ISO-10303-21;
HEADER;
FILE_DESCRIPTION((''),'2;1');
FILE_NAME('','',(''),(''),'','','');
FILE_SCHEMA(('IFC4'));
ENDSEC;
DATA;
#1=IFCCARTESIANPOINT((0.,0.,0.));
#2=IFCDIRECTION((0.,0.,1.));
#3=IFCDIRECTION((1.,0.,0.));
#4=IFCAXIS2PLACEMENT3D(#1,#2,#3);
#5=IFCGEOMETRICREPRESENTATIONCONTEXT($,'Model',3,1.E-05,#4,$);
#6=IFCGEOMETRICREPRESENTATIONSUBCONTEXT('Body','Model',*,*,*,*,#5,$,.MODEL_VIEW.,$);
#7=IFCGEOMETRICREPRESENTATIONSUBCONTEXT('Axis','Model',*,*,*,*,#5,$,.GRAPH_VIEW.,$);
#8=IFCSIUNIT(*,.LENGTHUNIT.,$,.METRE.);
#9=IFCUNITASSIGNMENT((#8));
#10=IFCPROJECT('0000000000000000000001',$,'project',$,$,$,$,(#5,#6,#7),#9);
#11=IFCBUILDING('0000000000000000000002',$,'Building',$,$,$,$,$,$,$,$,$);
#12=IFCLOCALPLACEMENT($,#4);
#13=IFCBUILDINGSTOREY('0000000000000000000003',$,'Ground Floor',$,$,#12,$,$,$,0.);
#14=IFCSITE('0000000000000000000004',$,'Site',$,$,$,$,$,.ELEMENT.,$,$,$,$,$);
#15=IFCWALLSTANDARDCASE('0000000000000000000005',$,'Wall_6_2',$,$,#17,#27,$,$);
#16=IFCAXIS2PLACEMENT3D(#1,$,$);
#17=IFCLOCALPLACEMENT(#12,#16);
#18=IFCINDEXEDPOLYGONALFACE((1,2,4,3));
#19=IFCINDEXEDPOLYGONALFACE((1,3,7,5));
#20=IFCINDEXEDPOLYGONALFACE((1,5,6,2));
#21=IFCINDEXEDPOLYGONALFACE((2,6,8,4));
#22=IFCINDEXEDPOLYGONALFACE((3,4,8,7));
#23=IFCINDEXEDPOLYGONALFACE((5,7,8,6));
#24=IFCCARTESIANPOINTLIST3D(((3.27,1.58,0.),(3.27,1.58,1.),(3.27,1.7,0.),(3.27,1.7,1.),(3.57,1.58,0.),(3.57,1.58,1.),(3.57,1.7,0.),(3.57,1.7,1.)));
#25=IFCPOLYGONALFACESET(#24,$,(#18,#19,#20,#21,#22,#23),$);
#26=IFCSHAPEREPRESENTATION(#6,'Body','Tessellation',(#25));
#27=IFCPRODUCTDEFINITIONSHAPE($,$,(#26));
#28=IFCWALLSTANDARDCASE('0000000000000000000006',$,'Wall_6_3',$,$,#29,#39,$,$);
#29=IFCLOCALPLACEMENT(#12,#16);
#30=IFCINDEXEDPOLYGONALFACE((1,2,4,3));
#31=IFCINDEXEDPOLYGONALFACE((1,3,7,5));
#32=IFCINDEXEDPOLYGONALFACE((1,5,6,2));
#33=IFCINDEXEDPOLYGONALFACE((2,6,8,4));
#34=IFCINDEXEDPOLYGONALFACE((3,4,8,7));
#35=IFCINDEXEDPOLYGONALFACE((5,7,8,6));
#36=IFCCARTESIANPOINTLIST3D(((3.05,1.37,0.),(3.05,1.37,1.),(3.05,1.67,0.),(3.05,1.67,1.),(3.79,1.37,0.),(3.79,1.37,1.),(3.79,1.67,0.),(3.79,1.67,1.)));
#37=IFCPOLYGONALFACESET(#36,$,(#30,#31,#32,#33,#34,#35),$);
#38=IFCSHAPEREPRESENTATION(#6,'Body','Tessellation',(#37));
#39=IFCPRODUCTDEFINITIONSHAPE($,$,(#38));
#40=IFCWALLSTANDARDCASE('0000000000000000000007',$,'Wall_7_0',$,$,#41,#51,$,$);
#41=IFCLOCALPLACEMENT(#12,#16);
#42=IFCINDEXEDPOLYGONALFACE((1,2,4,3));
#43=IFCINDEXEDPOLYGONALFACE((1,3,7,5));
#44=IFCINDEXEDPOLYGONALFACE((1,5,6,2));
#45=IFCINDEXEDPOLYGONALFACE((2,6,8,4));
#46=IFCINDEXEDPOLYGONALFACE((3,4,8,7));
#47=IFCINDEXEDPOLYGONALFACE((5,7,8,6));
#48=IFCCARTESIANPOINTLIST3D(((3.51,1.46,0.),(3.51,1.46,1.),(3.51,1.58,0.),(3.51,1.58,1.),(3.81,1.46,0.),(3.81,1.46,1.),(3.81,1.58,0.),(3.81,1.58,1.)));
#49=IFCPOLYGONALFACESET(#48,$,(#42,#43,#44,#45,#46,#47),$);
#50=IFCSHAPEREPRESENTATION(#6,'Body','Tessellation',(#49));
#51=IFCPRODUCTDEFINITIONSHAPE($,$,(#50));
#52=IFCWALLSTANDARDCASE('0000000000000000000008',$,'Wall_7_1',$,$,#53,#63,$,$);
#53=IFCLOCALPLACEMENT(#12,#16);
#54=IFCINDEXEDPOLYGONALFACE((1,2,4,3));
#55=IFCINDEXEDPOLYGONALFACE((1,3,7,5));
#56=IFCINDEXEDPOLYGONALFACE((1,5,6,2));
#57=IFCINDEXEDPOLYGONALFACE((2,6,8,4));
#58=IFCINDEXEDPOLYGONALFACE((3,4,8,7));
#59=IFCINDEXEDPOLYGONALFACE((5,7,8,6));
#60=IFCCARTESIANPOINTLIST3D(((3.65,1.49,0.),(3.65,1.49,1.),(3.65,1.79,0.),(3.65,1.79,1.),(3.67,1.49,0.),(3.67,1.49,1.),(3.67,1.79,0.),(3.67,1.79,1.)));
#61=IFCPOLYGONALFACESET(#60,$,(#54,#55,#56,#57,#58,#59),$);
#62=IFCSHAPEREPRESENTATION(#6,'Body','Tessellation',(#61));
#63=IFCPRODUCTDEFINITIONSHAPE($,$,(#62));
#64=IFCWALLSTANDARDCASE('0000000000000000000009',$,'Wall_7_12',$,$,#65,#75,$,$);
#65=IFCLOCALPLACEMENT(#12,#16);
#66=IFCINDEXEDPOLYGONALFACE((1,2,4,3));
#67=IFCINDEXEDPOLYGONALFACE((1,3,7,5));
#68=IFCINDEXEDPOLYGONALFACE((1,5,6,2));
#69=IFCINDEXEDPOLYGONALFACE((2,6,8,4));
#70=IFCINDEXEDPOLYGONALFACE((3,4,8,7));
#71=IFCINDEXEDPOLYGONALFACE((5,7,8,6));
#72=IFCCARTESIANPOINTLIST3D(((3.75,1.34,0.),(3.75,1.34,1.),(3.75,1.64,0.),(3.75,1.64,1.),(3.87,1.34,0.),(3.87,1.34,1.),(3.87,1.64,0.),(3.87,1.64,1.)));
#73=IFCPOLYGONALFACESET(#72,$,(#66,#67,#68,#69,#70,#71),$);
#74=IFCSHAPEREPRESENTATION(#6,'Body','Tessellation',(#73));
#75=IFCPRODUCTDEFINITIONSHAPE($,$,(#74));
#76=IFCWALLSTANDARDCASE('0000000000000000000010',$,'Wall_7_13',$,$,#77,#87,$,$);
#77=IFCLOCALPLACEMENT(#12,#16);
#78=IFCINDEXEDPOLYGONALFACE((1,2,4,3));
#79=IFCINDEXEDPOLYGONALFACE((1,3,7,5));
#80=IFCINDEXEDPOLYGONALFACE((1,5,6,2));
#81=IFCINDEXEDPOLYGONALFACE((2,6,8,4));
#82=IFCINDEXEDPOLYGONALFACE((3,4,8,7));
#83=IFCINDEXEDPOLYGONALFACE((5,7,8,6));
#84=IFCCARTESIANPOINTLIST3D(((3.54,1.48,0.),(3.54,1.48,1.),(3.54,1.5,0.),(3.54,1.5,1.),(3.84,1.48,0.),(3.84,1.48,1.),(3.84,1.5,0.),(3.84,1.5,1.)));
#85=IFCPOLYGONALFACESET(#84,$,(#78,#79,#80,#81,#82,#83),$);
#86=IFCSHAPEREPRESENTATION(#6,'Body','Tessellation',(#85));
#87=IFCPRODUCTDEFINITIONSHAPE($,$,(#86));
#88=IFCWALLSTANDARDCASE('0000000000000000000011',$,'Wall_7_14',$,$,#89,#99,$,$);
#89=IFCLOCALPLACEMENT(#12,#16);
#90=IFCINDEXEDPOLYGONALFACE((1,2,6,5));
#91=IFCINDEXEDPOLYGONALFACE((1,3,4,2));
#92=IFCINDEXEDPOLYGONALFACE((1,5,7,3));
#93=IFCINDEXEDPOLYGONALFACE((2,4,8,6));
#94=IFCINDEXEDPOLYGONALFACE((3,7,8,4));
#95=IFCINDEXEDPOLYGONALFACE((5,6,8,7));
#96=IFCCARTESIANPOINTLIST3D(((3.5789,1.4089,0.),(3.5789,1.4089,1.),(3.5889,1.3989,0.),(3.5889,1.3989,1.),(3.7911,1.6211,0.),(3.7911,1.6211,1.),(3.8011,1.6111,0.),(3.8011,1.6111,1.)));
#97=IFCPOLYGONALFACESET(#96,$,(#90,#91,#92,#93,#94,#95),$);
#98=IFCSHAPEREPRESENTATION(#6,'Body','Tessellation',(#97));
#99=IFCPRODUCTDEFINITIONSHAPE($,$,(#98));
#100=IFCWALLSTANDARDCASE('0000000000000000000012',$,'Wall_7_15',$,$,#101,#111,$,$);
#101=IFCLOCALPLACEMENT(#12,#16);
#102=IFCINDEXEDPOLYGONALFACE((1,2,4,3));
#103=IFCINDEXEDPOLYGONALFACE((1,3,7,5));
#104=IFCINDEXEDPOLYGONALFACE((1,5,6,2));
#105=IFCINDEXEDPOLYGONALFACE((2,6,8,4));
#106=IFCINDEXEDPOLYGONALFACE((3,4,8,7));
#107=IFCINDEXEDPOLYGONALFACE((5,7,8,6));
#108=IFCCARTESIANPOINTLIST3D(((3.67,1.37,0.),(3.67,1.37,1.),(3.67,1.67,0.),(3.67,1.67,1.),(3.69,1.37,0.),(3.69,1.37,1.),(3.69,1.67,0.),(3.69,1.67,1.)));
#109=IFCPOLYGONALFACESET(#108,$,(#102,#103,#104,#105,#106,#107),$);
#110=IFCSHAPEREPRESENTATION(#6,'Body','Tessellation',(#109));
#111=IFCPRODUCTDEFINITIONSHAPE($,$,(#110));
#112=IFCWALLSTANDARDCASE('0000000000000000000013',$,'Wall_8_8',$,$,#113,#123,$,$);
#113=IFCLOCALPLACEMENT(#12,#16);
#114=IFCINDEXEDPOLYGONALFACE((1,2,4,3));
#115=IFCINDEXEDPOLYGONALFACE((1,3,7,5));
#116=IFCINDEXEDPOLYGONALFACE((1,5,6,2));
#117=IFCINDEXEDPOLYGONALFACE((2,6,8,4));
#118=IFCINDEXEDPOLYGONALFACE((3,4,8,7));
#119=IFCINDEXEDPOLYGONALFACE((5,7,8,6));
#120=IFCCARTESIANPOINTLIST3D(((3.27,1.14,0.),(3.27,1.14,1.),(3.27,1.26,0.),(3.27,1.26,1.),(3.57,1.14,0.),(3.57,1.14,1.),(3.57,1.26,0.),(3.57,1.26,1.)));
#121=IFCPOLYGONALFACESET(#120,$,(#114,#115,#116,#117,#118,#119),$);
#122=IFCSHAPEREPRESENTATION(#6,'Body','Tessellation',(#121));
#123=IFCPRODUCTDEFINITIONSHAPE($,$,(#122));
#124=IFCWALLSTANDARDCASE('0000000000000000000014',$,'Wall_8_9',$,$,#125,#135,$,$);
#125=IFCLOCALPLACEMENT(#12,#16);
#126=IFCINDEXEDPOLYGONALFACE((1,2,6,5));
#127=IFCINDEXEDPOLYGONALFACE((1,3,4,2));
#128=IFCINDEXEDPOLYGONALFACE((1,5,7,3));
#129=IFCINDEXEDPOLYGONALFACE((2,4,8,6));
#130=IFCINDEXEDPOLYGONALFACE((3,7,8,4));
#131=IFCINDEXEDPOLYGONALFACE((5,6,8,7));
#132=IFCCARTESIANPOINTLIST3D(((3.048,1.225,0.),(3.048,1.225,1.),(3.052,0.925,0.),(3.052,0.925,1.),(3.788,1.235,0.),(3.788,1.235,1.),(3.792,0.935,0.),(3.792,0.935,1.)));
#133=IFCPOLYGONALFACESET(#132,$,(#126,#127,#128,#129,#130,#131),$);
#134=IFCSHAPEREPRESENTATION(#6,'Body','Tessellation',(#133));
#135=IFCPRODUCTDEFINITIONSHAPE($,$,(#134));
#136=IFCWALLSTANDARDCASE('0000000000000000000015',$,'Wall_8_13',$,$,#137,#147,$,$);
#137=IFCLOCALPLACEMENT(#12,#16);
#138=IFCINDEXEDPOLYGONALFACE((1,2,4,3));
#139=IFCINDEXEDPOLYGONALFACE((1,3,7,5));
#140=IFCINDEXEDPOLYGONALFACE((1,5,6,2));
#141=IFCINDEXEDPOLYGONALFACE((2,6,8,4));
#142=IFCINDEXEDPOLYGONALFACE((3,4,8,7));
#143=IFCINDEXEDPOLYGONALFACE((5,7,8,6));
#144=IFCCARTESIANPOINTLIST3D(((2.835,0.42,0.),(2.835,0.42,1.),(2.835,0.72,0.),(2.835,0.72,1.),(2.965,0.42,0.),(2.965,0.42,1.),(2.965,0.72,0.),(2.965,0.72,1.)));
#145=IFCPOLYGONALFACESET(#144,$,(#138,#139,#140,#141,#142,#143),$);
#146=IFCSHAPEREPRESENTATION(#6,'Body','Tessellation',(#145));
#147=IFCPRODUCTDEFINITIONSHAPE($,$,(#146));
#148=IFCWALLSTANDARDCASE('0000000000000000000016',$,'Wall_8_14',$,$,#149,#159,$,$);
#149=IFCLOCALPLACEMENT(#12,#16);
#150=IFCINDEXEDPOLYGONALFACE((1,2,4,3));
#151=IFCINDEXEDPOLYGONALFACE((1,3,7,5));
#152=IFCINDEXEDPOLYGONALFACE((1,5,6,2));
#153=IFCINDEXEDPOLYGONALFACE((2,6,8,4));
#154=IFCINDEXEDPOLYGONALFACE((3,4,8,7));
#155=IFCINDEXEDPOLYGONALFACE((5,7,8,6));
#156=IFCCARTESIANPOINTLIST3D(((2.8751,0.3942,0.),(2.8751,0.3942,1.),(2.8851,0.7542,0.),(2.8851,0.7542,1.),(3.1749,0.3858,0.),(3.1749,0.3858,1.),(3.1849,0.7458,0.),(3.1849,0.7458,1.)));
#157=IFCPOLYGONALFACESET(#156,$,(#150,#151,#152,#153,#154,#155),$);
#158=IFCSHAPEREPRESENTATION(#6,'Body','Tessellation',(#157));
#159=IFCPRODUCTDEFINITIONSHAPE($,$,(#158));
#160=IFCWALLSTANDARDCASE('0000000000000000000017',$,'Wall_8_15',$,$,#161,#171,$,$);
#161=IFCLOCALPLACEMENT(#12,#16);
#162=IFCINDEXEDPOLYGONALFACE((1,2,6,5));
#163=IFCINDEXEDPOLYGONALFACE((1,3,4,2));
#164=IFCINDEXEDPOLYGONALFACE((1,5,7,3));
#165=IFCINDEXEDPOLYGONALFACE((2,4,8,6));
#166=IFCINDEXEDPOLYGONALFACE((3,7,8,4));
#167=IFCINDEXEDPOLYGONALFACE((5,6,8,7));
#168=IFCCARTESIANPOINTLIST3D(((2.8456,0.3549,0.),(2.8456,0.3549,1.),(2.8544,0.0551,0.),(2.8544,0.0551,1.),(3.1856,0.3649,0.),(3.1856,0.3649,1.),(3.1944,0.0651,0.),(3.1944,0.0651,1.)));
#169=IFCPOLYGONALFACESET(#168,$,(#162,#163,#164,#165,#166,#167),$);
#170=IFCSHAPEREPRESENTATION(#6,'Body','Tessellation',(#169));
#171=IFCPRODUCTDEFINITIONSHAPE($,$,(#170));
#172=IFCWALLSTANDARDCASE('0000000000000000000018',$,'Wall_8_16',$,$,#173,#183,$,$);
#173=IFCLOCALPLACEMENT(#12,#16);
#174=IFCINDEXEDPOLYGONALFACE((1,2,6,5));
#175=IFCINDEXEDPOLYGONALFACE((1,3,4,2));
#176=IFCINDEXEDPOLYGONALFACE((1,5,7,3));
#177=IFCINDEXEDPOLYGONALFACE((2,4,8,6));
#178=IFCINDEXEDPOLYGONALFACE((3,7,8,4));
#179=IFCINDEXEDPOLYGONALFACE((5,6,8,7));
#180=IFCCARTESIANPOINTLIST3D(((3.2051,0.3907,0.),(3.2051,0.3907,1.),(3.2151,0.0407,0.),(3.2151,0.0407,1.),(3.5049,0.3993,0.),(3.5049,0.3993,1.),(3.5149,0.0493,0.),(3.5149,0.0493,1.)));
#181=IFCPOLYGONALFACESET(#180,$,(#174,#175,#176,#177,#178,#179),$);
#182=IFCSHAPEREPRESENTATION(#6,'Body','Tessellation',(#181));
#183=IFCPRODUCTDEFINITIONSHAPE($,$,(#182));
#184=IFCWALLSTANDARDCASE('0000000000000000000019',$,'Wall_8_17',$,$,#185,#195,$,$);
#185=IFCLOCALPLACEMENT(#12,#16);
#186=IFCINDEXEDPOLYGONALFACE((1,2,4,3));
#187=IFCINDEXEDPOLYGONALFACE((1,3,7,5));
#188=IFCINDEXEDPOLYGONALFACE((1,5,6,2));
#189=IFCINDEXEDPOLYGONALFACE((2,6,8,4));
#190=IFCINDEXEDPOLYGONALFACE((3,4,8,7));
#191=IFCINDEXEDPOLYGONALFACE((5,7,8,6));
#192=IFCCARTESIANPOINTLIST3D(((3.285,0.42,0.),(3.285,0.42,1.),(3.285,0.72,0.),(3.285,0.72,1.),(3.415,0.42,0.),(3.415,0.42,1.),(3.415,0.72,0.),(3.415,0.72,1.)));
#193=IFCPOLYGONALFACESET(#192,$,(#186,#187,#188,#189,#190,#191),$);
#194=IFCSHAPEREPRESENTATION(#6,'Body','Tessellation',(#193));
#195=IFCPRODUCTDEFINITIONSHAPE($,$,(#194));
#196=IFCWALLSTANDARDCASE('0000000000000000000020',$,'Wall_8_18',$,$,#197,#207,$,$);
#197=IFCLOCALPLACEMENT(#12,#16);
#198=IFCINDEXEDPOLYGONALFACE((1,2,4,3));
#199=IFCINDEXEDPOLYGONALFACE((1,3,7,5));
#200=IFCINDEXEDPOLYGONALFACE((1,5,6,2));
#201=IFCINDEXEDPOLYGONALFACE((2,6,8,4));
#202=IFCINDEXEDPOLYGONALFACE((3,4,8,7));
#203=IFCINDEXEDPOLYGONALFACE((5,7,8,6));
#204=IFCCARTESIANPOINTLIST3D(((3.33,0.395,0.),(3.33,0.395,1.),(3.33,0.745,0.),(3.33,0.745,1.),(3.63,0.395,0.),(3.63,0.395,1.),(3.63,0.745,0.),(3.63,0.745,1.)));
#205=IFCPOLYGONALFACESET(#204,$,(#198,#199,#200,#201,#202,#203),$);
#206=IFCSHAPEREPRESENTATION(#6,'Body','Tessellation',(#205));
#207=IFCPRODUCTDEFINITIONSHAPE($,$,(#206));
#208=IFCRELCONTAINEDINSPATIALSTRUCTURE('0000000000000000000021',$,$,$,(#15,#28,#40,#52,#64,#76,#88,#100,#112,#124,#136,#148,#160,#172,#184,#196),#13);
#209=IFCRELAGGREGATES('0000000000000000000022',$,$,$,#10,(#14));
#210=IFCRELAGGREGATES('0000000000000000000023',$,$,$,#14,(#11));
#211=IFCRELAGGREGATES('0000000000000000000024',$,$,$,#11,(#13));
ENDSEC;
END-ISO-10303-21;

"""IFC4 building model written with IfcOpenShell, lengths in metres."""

from ifc_helpers import new_model, si_unit, frame, origin_with_axes, origin_2d, place, context, subcontext, project, spatial, rectangle, extrude, element, save


model = new_model("IFC4")

# Units and contexts
model_context = context("Model", 3, precision=1e-05, world=origin_with_axes())
body_context = subcontext(model_context, "Body", "Model", "MODEL_VIEW")
axis_context = subcontext(model_context, "Axis", "Model", "GRAPH_VIEW")
ifc_project = project(units=[si_unit("LENGTHUNIT", "METRE")], contexts=[model_context, body_context, axis_context])

# Site, building, storey
site = spatial("IfcSite", under=ifc_project, Name="Site", CompositionType="ELEMENT")
building = spatial("IfcBuilding", under=site, Name="Building")
storey_placement = place(None, origin_with_axes())
storey = spatial("IfcBuildingStorey", under=building, at=storey_placement, Name="Ground Floor", Elevation=0.0)

# Walls
wall_1_placement = place(storey_placement, frame((3.42, 1.64, 0.0), z_axis=(0.0, 0.0, 1.0), x_axis=(0.0, -1.0, 0.0)))
element("IfcWallStandardCase", 1, at=wall_1_placement, inside=storey, Name="Wall_6_2", context=body_context, shape_type="SweptSolid", body=[
    extrude(rectangle(XDim=0.12, YDim=0.3, at=origin_2d()), origin_with_axes(), (0.0, 0.0, 1.0), 1.0),
])
wall_2_placement = place(storey_placement, frame((3.42, 1.52, 0.0), z_axis=(0.0, 0.0, 1.0), x_axis=(-1.0, 0.0, 0.0)))
element("IfcWallStandardCase", 2, at=wall_2_placement, inside=storey, Name="Wall_6_3", context=body_context, shape_type="SweptSolid", body=[
    extrude(rectangle(XDim=0.74, YDim=0.3, at=origin_2d()), origin_with_axes(), (0.0, 0.0, 1.0), 1.0),
])
wall_3_placement = place(storey_placement, frame((3.66, 1.52, 0.0), z_axis=(0.0, 0.0, 1.0), x_axis=(0.0, 1.0, 0.0)))
element("IfcWallStandardCase", 3, at=wall_3_placement, inside=storey, Name="Wall_7_0", context=body_context, shape_type="SweptSolid", body=[
    extrude(rectangle(XDim=0.12, YDim=0.3, at=origin_2d()), origin_with_axes(), (0.0, 0.0, 1.0), 1.0),
])
wall_4_placement = place(storey_placement, frame((3.66, 1.64, 0.0), z_axis=(0.0, 0.0, 1.0), x_axis=(1.0, 0.0, 0.0)))
element("IfcWallStandardCase", 4, at=wall_4_placement, inside=storey, Name="Wall_7_1", context=body_context, shape_type="SweptSolid", body=[
    extrude(rectangle(XDim=0.02, YDim=0.3, at=origin_2d()), origin_with_axes(), (0.0, 0.0, 1.0), 1.0),
])
wall_5_placement = place(storey_placement, frame((3.81, 1.49, 0.0), z_axis=(0.0, 0.0, 1.0), x_axis=(-1.0, 0.0, 0.0)))
element("IfcWallStandardCase", 5, at=wall_5_placement, inside=storey, Name="Wall_7_12", context=body_context, shape_type="SweptSolid", body=[
    extrude(rectangle(XDim=0.12, YDim=0.3, at=origin_2d()), origin_with_axes(), (0.0, 0.0, 1.0), 1.0),
])
wall_6_placement = place(storey_placement, frame((3.69, 1.49, 0.0), z_axis=(0.0, 0.0, 1.0), x_axis=(0.0, 1.0, 0.0)))
element("IfcWallStandardCase", 6, at=wall_6_placement, inside=storey, Name="Wall_7_13", context=body_context, shape_type="SweptSolid", body=[
    extrude(rectangle(XDim=0.02, YDim=0.3, at=origin_2d()), origin_with_axes(), (0.0, 0.0, 1.0), 1.0),
])
wall_7_placement = place(storey_placement, frame((3.69, 1.51, 0.0), z_axis=(0.0, 0.0, 1.0), x_axis=(-0.707107, 0.707107, 0.0)))
element("IfcWallStandardCase", 7, at=wall_7_placement, inside=storey, Name="Wall_7_14", context=body_context, shape_type="SweptSolid", body=[
    extrude(rectangle(XDim=0.0141, YDim=0.3, at=origin_2d()), origin_with_axes(), (0.0, 0.0, 1.0), 1.0),
])
wall_8_placement = place(storey_placement, frame((3.68, 1.52, 0.0), z_axis=(0.0, 0.0, 1.0), x_axis=(-1.0, 0.0, 0.0)))
element("IfcWallStandardCase", 8, at=wall_8_placement, inside=storey, Name="Wall_7_15", context=body_context, shape_type="SweptSolid", body=[
    extrude(rectangle(XDim=0.02, YDim=0.3, at=origin_2d()), origin_with_axes(), (0.0, 0.0, 1.0), 1.0),
])
wall_9_placement = place(storey_placement, frame((3.42, 1.2, 0.0), z_axis=(0.0, 0.0, 1.0), x_axis=(0.0, -1.0, 0.0)))
element("IfcWallStandardCase", 9, at=wall_9_placement, inside=storey, Name="Wall_8_8", context=body_context, shape_type="SweptSolid", body=[
    extrude(rectangle(XDim=0.12, YDim=0.3, at=origin_2d()), origin_with_axes(), (0.0, 0.0, 1.0), 1.0),
])
wall_10_placement = place(storey_placement, frame((3.42, 1.08, 0.0), z_axis=(0.0, 0.0, 1.0), x_axis=(-0.999909, -0.013512, 0.0)))
element("IfcWallStandardCase", 10, at=wall_10_placement, inside=storey, Name="Wall_8_9", context=body_context, shape_type="SweptSolid", body=[
    extrude(rectangle(XDim=0.7401, YDim=0.3, at=origin_2d()), origin_with_axes(), (0.0, 0.0, 1.0), 1.0),
])
wall_11_placement = place(storey_placement, frame((2.9, 0.57, 0.0), z_axis=(0.0, 0.0, 1.0), x_axis=(1.0, 0.0, 0.0)))
element("IfcWallStandardCase", 11, at=wall_11_placement, inside=storey, Name="Wall_8_13", context=body_context, shape_type="SweptSolid", body=[
    extrude(rectangle(XDim=0.13, YDim=0.3, at=origin_2d()), origin_with_axes(), (0.0, 0.0, 1.0), 1.0),
])
wall_12_placement = place(storey_placement, frame((3.03, 0.57, 0.0), z_axis=(0.0, 0.0, 1.0), x_axis=(-0.027767, -0.999614, 0.0)))
element("IfcWallStandardCase", 12, at=wall_12_placement, inside=storey, Name="Wall_8_14", context=body_context, shape_type="SweptSolid", body=[
    extrude(rectangle(XDim=0.3601, YDim=0.3, at=origin_2d()), origin_with_axes(), (0.0, 0.0, 1.0), 1.0),
])
wall_13_placement = place(storey_placement, frame((3.02, 0.21, 0.0), z_axis=(0.0, 0.0, 1.0), x_axis=(0.999568, 0.029399, 0.0)))
element("IfcWallStandardCase", 13, at=wall_13_placement, inside=storey, Name="Wall_8_15", context=body_context, shape_type="SweptSolid", body=[
    extrude(rectangle(XDim=0.3401, YDim=0.3, at=origin_2d()), origin_with_axes(), (0.0, 0.0, 1.0), 1.0),
])
wall_14_placement = place(storey_placement, frame((3.36, 0.22, 0.0), z_axis=(0.0, 0.0, 1.0), x_axis=(-0.02856, 0.999592, 0.0)))
element("IfcWallStandardCase", 14, at=wall_14_placement, inside=storey, Name="Wall_8_16", context=body_context, shape_type="SweptSolid", body=[
    extrude(rectangle(XDim=0.3501, YDim=0.3, at=origin_2d()), origin_with_axes(), (0.0, 0.0, 1.0), 1.0),
])
wall_15_placement = place(storey_placement, frame((3.35, 0.57, 0.0), z_axis=(0.0, 0.0, 1.0), x_axis=(1.0, 0.0, 0.0)))
element("IfcWallStandardCase", 15, at=wall_15_placement, inside=storey, Name="Wall_8_17", context=body_context, shape_type="SweptSolid", body=[
    extrude(rectangle(XDim=0.13, YDim=0.3, at=origin_2d()), origin_with_axes(), (0.0, 0.0, 1.0), 1.0),
])
wall_16_placement = place(storey_placement, frame((3.48, 0.57, 0.0), z_axis=(0.0, 0.0, 1.0), x_axis=(0.0, -1.0, 0.0)))
element("IfcWallStandardCase", 16, at=wall_16_placement, inside=storey, Name="Wall_8_18", context=body_context, shape_type="SweptSolid", body=[
    extrude(rectangle(XDim=0.35, YDim=0.3, at=origin_2d()), origin_with_axes(), (0.0, 0.0, 1.0), 1.0),
])

save(model, "model.ifc")
